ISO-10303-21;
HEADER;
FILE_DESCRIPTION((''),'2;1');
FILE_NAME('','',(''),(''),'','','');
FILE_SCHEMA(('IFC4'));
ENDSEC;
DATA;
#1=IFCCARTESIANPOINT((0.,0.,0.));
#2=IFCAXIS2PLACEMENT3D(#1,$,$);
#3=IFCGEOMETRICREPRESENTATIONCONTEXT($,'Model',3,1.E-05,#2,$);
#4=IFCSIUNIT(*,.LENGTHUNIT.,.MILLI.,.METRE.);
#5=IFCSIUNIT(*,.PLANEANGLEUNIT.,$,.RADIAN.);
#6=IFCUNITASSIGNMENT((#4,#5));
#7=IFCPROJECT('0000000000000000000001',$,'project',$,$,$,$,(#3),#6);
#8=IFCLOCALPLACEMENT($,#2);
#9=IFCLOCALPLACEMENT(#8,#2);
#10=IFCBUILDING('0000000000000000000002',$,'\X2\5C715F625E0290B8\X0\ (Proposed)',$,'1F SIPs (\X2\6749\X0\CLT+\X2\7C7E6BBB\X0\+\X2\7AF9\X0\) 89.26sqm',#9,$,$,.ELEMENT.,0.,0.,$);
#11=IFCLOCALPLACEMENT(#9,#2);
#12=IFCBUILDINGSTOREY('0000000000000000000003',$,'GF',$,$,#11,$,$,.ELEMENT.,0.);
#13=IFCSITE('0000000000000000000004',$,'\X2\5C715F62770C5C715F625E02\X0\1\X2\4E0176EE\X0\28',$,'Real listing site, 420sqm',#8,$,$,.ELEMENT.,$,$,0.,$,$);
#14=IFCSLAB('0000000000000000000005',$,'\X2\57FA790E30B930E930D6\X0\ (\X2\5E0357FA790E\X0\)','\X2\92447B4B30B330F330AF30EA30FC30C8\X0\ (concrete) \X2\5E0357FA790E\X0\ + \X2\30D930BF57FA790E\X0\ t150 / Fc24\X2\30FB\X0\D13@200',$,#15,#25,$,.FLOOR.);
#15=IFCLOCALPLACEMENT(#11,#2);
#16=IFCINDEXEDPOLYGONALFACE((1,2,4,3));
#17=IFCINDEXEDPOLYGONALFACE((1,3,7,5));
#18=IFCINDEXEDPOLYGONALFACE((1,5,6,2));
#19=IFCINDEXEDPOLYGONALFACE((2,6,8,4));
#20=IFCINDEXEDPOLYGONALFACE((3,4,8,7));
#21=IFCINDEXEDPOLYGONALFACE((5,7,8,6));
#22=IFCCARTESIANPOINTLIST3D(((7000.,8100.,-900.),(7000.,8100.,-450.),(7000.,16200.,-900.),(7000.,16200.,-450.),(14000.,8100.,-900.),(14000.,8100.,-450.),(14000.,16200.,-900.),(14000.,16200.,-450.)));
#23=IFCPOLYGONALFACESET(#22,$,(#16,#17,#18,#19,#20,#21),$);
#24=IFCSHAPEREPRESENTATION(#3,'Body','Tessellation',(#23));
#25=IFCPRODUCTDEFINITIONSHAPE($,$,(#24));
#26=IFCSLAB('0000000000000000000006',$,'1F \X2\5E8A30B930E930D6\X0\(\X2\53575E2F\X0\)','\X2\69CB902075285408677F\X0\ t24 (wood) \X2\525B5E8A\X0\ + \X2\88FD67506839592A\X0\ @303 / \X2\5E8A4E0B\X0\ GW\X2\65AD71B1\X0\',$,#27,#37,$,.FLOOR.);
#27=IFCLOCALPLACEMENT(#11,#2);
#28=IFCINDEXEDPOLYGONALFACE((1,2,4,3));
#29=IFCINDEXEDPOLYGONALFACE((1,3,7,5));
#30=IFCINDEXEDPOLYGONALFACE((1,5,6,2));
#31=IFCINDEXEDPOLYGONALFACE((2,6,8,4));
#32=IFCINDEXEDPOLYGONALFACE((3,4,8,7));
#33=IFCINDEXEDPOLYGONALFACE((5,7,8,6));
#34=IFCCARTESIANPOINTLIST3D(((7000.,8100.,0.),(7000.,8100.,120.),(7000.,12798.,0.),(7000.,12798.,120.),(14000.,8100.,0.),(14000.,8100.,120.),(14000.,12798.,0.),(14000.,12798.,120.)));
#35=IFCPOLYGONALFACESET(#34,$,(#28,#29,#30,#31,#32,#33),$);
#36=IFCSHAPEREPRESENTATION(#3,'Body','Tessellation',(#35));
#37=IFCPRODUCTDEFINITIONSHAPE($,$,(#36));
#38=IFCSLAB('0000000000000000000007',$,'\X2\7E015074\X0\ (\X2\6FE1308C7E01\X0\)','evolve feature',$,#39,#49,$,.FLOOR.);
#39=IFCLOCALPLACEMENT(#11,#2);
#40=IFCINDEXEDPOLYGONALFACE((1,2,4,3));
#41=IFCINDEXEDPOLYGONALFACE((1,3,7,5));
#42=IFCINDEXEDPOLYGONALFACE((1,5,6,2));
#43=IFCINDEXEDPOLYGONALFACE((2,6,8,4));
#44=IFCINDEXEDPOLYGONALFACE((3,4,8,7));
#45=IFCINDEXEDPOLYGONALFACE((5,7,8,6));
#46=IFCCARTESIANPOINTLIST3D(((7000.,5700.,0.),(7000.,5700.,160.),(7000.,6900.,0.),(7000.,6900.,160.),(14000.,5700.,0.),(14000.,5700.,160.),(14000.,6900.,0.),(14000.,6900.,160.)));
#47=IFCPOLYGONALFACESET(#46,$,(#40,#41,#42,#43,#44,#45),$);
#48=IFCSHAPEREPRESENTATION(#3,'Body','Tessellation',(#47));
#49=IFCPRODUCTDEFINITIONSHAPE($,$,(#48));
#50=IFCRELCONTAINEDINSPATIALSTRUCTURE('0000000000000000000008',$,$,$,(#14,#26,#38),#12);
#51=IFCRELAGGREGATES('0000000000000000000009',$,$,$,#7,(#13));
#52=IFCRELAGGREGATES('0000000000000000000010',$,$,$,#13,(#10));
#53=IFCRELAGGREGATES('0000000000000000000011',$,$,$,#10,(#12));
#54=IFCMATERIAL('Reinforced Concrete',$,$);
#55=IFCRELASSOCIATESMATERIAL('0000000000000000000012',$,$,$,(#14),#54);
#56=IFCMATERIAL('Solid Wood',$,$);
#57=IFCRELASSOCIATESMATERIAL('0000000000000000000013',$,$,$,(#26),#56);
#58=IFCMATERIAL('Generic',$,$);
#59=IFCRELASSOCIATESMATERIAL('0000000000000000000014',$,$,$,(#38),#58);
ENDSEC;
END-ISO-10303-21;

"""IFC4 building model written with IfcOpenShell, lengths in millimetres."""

from ifc_helpers import new_model, si_unit, frame, frame_2d, origin, place, context, project, spatial, rectangle, extrude, material, element, save


model = new_model("IFC4")

# Units and contexts
model_context = context("Model", 3, precision=1e-05, world=origin())
ifc_project = project(units=[si_unit("LENGTHUNIT", "METRE", prefix="MILLI"), si_unit("PLANEANGLEUNIT", "RADIAN")], contexts=[model_context])

# Site, building, storey
site_placement = place(None, origin())
site = spatial("IfcSite", under=ifc_project, at=site_placement, Name="山形県山形市1丁目28", ObjectType="Real listing site, 420sqm", CompositionType="ELEMENT", RefElevation=0.0)
building_placement = place(site_placement, origin())
building = spatial("IfcBuilding", under=site, at=building_placement, Name="山形市邸 (Proposed)", ObjectType="1F SIPs (杉CLT+籾殻+竹) 89.26sqm", CompositionType="ELEMENT", ElevationOfRefHeight=0.0, ElevationOfTerrain=0.0)
storey_placement = place(building_placement, origin())
storey = spatial("IfcBuildingStorey", under=building, at=storey_placement, Name="GF", CompositionType="ELEMENT", Elevation=0.0)

# Slabs
ifc_material_1 = material(Name="Reinforced Concrete")
slab_1_placement = place(storey_placement, frame((3500.0, 4050.0, -450.0)))
element("IfcSlab", 1, at=slab_1_placement, inside=storey, material=ifc_material_1, Name="基礎スラブ (布基礎)", Description="鉄筋コンクリート (concrete) 布基礎 + ベタ基礎 t150 / Fc24・D13@200", PredefinedType="FLOOR", context=model_context, shape_type="SweptSolid", body=[
    extrude(rectangle(XDim=7000.0, YDim=8100.0, at=frame_2d((3500.0, 4050.0))), frame((3500.0, 4050.0, -450.0)), (0.0, 0.0, 1.0), 450.0),
])
ifc_material_2 = material(Name="Solid Wood")
slab_2_placement = place(storey_placement, frame((3500.0, 4050.0, 0.0)))
element("IfcSlab", 2, at=slab_2_placement, inside=storey, material=ifc_material_2, Name="1F 床スラブ(南帯)", Description="構造用合板 t24 (wood) 剛床 + 製材根太 @303 / 床下 GW断熱", PredefinedType="FLOOR", context=model_context, shape_type="SweptSolid", body=[
    extrude(rectangle(XDim=7000.0, YDim=4698.0, at=frame_2d((3500.0, 2349.0))), frame((3500.0, 4050.0, 0.0)), (0.0, 0.0, 1.0), 120.0),
])
ifc_material_3 = material(Name="Generic")
slab_3_placement = place(storey_placement, frame((3500.0, 2850.0, 0.0)))
element("IfcSlab", 3, at=slab_3_placement, inside=storey, material=ifc_material_3, Name="縁側 (濡れ縁)", Description="evolve feature", PredefinedType="FLOOR", context=model_context, shape_type="SweptSolid", body=[
    extrude(rectangle(XDim=7000.0, YDim=1200.0, at=frame_2d((3500.0, 600.0))), frame((3500.0, 2850.0, 0.0)), (0.0, 0.0, 1.0), 160.0),
])

save(model, "model.ifc")
